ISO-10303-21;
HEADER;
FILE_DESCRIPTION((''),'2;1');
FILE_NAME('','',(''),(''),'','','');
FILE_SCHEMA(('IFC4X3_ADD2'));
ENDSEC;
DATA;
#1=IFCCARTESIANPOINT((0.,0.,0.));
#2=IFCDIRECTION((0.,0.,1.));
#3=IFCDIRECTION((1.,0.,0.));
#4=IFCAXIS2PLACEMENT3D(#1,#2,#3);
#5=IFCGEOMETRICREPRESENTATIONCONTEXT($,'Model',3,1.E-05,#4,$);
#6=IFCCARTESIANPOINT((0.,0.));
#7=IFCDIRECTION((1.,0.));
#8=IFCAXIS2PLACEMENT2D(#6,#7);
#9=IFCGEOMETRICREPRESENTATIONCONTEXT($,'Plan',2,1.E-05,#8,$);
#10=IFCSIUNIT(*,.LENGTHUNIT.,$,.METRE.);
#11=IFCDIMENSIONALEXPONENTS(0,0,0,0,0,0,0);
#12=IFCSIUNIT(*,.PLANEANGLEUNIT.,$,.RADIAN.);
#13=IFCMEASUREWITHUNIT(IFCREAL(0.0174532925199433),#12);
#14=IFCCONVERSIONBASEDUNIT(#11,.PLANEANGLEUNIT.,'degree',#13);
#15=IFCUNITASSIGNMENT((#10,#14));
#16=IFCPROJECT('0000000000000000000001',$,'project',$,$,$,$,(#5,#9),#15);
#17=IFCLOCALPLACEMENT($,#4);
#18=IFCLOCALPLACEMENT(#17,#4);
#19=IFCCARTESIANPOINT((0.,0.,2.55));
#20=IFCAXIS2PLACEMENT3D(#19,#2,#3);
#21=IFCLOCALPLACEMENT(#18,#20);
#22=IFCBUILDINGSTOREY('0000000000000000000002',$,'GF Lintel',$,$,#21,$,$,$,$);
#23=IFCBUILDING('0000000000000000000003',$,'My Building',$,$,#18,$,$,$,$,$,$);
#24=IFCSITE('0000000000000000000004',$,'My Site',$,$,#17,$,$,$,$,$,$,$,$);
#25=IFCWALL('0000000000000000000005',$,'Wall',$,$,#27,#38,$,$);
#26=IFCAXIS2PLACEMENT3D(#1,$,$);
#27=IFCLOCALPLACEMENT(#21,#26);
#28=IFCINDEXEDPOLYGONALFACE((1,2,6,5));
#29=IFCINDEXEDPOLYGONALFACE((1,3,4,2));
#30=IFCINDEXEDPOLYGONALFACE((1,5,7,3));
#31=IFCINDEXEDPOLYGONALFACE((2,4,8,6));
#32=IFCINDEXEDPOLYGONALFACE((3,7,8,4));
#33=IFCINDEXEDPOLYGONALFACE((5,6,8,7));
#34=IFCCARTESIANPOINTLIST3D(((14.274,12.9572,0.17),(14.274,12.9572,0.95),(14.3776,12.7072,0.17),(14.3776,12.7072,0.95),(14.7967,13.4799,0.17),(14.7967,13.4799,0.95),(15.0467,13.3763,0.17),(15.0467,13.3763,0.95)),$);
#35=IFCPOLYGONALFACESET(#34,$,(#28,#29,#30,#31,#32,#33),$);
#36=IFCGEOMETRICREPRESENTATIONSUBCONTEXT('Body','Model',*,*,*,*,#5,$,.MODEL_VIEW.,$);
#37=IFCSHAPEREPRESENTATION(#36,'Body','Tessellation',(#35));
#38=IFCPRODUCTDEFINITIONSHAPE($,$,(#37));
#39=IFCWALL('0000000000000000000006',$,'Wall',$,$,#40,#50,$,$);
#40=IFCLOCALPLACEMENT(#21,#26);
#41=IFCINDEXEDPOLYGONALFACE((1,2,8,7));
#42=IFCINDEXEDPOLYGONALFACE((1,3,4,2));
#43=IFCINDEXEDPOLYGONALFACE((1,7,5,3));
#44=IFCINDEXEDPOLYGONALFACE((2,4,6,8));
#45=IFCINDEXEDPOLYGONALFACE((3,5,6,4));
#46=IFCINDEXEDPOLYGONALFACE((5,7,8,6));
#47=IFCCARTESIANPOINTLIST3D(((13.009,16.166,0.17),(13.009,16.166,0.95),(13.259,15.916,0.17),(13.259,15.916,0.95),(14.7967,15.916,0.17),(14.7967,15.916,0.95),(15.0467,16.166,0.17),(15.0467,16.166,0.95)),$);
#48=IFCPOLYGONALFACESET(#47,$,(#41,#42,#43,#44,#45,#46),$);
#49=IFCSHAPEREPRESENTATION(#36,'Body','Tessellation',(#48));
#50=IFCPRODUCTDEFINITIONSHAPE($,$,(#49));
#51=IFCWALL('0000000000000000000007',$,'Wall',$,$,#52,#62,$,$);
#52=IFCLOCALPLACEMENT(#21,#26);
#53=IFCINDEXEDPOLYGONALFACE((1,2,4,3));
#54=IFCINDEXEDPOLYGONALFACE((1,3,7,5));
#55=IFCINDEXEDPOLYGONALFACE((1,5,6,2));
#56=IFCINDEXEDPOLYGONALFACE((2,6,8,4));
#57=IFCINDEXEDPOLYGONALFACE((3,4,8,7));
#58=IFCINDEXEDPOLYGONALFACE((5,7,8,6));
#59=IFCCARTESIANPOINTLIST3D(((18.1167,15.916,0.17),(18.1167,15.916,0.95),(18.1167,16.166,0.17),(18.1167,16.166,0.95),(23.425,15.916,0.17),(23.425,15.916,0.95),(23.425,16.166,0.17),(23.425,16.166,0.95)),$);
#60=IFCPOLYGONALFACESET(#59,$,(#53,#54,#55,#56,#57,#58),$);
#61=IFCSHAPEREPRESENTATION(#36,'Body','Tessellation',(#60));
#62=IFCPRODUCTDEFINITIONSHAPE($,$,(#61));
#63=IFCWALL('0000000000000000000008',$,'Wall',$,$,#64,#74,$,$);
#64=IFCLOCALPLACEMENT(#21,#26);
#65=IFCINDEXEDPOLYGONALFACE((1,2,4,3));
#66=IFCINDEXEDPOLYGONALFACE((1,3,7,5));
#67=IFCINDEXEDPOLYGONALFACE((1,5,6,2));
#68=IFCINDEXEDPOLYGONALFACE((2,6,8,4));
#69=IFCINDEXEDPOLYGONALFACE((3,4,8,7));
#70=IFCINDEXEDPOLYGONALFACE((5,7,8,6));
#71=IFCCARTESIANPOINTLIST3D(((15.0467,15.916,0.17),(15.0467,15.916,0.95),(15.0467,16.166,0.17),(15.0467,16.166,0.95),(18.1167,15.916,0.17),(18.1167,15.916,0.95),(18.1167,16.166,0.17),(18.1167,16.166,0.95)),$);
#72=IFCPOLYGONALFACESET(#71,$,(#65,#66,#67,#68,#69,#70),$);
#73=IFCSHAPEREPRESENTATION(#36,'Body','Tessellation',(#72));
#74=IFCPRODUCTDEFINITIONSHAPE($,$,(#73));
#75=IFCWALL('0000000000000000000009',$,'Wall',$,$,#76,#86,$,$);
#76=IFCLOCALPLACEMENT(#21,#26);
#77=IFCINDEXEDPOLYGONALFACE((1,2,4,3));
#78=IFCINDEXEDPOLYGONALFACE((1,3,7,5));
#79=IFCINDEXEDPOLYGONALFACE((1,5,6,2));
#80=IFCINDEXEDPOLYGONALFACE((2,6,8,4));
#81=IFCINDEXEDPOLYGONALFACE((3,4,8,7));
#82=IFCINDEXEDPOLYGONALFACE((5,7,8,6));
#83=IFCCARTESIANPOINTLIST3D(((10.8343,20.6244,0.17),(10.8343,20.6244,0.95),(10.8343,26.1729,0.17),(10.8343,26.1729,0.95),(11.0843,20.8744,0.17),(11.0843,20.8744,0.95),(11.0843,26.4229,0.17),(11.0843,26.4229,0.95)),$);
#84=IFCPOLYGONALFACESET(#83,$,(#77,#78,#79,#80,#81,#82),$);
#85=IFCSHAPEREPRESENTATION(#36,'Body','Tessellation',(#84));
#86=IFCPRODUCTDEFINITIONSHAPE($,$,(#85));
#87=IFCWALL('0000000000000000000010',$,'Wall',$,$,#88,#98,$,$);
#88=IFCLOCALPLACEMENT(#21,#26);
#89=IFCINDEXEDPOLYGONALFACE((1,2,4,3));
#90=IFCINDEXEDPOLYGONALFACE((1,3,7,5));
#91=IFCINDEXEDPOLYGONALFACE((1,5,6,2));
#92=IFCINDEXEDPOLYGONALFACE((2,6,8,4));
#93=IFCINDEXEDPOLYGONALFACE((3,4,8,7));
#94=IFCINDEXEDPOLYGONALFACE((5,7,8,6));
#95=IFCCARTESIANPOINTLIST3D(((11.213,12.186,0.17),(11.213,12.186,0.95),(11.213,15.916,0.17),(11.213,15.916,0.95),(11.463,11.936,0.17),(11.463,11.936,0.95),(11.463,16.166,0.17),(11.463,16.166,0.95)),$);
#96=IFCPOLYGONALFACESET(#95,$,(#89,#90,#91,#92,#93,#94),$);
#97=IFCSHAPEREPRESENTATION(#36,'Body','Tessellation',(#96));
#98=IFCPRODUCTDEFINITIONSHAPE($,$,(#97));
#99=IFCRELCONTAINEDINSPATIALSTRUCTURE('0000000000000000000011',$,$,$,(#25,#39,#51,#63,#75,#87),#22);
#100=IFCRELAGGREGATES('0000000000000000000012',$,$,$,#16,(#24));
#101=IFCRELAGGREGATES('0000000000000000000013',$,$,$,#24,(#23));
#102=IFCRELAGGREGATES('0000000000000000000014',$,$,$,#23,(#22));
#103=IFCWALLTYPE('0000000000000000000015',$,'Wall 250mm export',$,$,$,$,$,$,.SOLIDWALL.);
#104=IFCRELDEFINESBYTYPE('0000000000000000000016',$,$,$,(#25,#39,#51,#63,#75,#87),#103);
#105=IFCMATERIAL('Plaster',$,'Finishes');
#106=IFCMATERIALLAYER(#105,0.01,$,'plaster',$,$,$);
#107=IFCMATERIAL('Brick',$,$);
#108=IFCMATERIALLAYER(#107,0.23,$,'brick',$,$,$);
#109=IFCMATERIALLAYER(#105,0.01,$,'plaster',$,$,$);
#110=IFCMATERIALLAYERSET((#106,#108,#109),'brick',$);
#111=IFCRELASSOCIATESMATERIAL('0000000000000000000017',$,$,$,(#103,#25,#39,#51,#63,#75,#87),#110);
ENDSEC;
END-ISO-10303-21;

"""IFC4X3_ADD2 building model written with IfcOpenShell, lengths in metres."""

from ifc_helpers import new_model, entity, si_unit, converted_unit, frame, origin_with_axes, origin_2d_with_axis, place, context, subcontext, project, spatial, line, indexed_curve, outline, extrude, material, layer, layer_set, layer_usage, type_object, element, save


model = new_model("IFC4X3_ADD2")

# Units and contexts
model_context = context("Model", 3, precision=1e-05, world=origin_with_axes())
plan_context = context("Plan", 2, precision=1e-05, world=origin_2d_with_axis())
body_context = subcontext(model_context, "Body", "Model", "MODEL_VIEW")
ifc_project = project(units=[si_unit("LENGTHUNIT", "METRE"), converted_unit("PLANEANGLEUNIT", "degree", entity("IfcReal", 0.0174532925199433), si_unit("PLANEANGLEUNIT", "RADIAN"), dimensions=[0, 0, 0, 0, 0, 0, 0])], contexts=[model_context, plan_context])

# Site, building, storey
site_placement = place(None, origin_with_axes())
site = spatial("IfcSite", under=ifc_project, at=site_placement, Name="My Site")
building_placement = place(site_placement, origin_with_axes())
building = spatial("IfcBuilding", under=site, at=building_placement, Name="My Building")
storey_placement = place(building_placement, frame((0.0, 0.0, 2.55), z_axis=(0.0, 0.0, 1.0), x_axis=(1.0, 0.0, 0.0)))
storey = spatial("IfcBuildingStorey", under=building, at=storey_placement, Name="GF Lintel")

# Walls
ifc_material_1 = material(Name="Plaster", Category="Finishes")
ifc_layer_1 = layer(ifc_material_1, 0.01, Name="plaster")
ifc_material_2 = material(Name="Brick")
ifc_layer_2 = layer(ifc_material_2, 0.23, Name="brick")
ifc_layer_3 = layer(ifc_material_1, 0.01, Name="plaster")
ifc_layer_set = layer_set([ifc_layer_1, ifc_layer_2, ifc_layer_3], Name="brick")
wall_type = type_object("IfcWallType", Name="Wall 250mm export", PredefinedType="SOLIDWALL", material=ifc_layer_set)
ifc_layer_usage_1 = layer_usage(ifc_layer_set, "AXIS2", "POSITIVE", 0.0)
wall_1_placement = place(storey_placement, frame((14.3776, 12.7072, 0.17), z_axis=(0.0, 0.0, 1.0), x_axis=(0.707107, 0.707107, 0.0)))
element("IfcWall", 1, at=wall_1_placement, inside=storey, type_object=wall_type, material=ifc_layer_usage_1, Name="Wall", context=body_context, shape_type="SweptSolid", body=[
    extrude(outline(indexed_curve([(0.0, 0.0), (0.1036, 0.25), (0.8427, 0.25), (0.9463, 0.0)], segments=[line(1, 2, 3, 4, 1)])), origin_with_axes(), (0.0, 0.0, 1.0), 0.78),
])
ifc_layer_usage_2 = layer_usage(ifc_layer_set, "AXIS2", "POSITIVE", 0.0)
wall_2_placement = place(storey_placement, frame((13.259, 15.916, 0.17), z_axis=(0.0, 0.0, 1.0), x_axis=(1.0, 0.0, 0.0)))
element("IfcWall", 2, at=wall_2_placement, inside=storey, type_object=wall_type, material=ifc_layer_usage_2, Name="Wall", context=body_context, shape_type="SweptSolid", body=[
    extrude(outline(indexed_curve([(0.0, 0.0), (-0.25, 0.25), (1.7877, 0.25), (1.5377, 0.0)], segments=[line(1, 2, 3, 4, 1)])), origin_with_axes(), (0.0, 0.0, 1.0), 0.78),
])
ifc_layer_usage_3 = layer_usage(ifc_layer_set, "AXIS2", "POSITIVE", 0.0)
wall_3_placement = place(storey_placement, frame((18.1167, 15.916, 0.17), z_axis=(0.0, 0.0, 1.0), x_axis=(1.0, 0.0, 0.0)))
element("IfcWall", 3, at=wall_3_placement, inside=storey, type_object=wall_type, material=ifc_layer_usage_3, Name="Wall", context=body_context, shape_type="SweptSolid", body=[
    extrude(outline(indexed_curve([(0.0, 0.0), (0.0, 0.25), (5.3083, 0.25), (5.3083, 0.0)], segments=[line(1, 2, 3, 4, 1)])), origin_with_axes(), (0.0, 0.0, 1.0), 0.78),
])
ifc_layer_usage_4 = layer_usage(ifc_layer_set, "AXIS2", "POSITIVE", 0.0)
wall_4_placement = place(storey_placement, frame((15.0467, 15.916, 0.17), z_axis=(0.0, 0.0, 1.0), x_axis=(1.0, 0.0, 0.0)))
element("IfcWall", 4, at=wall_4_placement, inside=storey, type_object=wall_type, material=ifc_layer_usage_4, Name="Wall", context=body_context, shape_type="SweptSolid", body=[
    extrude(outline(indexed_curve([(0.0, 0.0), (0.0, 0.25), (3.07, 0.25), (3.07, 0.0)], segments=[line(1, 2, 3, 4, 1)])), origin_with_axes(), (0.0, 0.0, 1.0), 0.78),
])
ifc_layer_usage_5 = layer_usage(ifc_layer_set, "AXIS2", "POSITIVE", 0.0)
wall_5_placement = place(storey_placement, frame((11.0843, 20.6244, 0.17), z_axis=(0.0, 0.0, 1.0), x_axis=(0.0, 1.0, 0.0)))
element("IfcWall", 5, at=wall_5_placement, inside=storey, type_object=wall_type, material=ifc_layer_usage_5, Name="Wall", context=body_context, shape_type="SweptSolid", body=[
    extrude(outline(indexed_curve([(0.25, 0.0), (0.0, 0.25), (5.5485, 0.25), (5.7985, 0.0)], segments=[line(1, 2, 3, 4, 1)])), origin_with_axes(), (0.0, 0.0, 1.0), 0.78),
])
ifc_layer_usage_6 = layer_usage(ifc_layer_set, "AXIS2", "POSITIVE", 0.0)
wall_6_placement = place(storey_placement, frame((11.463, 11.936, 0.17), z_axis=(0.0, 0.0, 1.0), x_axis=(0.0, 1.0, 0.0)))
element("IfcWall", 6, at=wall_6_placement, inside=storey, type_object=wall_type, material=ifc_layer_usage_6, Name="Wall", context=body_context, shape_type="SweptSolid", body=[
    extrude(outline(indexed_curve([(0.0, 0.0), (0.25, 0.25), (3.98, 0.25), (4.23, 0.0)], segments=[line(1, 2, 3, 4, 1)])), origin_with_axes(), (0.0, 0.0, 1.0), 0.78),
])

save(model, "model.ifc")
